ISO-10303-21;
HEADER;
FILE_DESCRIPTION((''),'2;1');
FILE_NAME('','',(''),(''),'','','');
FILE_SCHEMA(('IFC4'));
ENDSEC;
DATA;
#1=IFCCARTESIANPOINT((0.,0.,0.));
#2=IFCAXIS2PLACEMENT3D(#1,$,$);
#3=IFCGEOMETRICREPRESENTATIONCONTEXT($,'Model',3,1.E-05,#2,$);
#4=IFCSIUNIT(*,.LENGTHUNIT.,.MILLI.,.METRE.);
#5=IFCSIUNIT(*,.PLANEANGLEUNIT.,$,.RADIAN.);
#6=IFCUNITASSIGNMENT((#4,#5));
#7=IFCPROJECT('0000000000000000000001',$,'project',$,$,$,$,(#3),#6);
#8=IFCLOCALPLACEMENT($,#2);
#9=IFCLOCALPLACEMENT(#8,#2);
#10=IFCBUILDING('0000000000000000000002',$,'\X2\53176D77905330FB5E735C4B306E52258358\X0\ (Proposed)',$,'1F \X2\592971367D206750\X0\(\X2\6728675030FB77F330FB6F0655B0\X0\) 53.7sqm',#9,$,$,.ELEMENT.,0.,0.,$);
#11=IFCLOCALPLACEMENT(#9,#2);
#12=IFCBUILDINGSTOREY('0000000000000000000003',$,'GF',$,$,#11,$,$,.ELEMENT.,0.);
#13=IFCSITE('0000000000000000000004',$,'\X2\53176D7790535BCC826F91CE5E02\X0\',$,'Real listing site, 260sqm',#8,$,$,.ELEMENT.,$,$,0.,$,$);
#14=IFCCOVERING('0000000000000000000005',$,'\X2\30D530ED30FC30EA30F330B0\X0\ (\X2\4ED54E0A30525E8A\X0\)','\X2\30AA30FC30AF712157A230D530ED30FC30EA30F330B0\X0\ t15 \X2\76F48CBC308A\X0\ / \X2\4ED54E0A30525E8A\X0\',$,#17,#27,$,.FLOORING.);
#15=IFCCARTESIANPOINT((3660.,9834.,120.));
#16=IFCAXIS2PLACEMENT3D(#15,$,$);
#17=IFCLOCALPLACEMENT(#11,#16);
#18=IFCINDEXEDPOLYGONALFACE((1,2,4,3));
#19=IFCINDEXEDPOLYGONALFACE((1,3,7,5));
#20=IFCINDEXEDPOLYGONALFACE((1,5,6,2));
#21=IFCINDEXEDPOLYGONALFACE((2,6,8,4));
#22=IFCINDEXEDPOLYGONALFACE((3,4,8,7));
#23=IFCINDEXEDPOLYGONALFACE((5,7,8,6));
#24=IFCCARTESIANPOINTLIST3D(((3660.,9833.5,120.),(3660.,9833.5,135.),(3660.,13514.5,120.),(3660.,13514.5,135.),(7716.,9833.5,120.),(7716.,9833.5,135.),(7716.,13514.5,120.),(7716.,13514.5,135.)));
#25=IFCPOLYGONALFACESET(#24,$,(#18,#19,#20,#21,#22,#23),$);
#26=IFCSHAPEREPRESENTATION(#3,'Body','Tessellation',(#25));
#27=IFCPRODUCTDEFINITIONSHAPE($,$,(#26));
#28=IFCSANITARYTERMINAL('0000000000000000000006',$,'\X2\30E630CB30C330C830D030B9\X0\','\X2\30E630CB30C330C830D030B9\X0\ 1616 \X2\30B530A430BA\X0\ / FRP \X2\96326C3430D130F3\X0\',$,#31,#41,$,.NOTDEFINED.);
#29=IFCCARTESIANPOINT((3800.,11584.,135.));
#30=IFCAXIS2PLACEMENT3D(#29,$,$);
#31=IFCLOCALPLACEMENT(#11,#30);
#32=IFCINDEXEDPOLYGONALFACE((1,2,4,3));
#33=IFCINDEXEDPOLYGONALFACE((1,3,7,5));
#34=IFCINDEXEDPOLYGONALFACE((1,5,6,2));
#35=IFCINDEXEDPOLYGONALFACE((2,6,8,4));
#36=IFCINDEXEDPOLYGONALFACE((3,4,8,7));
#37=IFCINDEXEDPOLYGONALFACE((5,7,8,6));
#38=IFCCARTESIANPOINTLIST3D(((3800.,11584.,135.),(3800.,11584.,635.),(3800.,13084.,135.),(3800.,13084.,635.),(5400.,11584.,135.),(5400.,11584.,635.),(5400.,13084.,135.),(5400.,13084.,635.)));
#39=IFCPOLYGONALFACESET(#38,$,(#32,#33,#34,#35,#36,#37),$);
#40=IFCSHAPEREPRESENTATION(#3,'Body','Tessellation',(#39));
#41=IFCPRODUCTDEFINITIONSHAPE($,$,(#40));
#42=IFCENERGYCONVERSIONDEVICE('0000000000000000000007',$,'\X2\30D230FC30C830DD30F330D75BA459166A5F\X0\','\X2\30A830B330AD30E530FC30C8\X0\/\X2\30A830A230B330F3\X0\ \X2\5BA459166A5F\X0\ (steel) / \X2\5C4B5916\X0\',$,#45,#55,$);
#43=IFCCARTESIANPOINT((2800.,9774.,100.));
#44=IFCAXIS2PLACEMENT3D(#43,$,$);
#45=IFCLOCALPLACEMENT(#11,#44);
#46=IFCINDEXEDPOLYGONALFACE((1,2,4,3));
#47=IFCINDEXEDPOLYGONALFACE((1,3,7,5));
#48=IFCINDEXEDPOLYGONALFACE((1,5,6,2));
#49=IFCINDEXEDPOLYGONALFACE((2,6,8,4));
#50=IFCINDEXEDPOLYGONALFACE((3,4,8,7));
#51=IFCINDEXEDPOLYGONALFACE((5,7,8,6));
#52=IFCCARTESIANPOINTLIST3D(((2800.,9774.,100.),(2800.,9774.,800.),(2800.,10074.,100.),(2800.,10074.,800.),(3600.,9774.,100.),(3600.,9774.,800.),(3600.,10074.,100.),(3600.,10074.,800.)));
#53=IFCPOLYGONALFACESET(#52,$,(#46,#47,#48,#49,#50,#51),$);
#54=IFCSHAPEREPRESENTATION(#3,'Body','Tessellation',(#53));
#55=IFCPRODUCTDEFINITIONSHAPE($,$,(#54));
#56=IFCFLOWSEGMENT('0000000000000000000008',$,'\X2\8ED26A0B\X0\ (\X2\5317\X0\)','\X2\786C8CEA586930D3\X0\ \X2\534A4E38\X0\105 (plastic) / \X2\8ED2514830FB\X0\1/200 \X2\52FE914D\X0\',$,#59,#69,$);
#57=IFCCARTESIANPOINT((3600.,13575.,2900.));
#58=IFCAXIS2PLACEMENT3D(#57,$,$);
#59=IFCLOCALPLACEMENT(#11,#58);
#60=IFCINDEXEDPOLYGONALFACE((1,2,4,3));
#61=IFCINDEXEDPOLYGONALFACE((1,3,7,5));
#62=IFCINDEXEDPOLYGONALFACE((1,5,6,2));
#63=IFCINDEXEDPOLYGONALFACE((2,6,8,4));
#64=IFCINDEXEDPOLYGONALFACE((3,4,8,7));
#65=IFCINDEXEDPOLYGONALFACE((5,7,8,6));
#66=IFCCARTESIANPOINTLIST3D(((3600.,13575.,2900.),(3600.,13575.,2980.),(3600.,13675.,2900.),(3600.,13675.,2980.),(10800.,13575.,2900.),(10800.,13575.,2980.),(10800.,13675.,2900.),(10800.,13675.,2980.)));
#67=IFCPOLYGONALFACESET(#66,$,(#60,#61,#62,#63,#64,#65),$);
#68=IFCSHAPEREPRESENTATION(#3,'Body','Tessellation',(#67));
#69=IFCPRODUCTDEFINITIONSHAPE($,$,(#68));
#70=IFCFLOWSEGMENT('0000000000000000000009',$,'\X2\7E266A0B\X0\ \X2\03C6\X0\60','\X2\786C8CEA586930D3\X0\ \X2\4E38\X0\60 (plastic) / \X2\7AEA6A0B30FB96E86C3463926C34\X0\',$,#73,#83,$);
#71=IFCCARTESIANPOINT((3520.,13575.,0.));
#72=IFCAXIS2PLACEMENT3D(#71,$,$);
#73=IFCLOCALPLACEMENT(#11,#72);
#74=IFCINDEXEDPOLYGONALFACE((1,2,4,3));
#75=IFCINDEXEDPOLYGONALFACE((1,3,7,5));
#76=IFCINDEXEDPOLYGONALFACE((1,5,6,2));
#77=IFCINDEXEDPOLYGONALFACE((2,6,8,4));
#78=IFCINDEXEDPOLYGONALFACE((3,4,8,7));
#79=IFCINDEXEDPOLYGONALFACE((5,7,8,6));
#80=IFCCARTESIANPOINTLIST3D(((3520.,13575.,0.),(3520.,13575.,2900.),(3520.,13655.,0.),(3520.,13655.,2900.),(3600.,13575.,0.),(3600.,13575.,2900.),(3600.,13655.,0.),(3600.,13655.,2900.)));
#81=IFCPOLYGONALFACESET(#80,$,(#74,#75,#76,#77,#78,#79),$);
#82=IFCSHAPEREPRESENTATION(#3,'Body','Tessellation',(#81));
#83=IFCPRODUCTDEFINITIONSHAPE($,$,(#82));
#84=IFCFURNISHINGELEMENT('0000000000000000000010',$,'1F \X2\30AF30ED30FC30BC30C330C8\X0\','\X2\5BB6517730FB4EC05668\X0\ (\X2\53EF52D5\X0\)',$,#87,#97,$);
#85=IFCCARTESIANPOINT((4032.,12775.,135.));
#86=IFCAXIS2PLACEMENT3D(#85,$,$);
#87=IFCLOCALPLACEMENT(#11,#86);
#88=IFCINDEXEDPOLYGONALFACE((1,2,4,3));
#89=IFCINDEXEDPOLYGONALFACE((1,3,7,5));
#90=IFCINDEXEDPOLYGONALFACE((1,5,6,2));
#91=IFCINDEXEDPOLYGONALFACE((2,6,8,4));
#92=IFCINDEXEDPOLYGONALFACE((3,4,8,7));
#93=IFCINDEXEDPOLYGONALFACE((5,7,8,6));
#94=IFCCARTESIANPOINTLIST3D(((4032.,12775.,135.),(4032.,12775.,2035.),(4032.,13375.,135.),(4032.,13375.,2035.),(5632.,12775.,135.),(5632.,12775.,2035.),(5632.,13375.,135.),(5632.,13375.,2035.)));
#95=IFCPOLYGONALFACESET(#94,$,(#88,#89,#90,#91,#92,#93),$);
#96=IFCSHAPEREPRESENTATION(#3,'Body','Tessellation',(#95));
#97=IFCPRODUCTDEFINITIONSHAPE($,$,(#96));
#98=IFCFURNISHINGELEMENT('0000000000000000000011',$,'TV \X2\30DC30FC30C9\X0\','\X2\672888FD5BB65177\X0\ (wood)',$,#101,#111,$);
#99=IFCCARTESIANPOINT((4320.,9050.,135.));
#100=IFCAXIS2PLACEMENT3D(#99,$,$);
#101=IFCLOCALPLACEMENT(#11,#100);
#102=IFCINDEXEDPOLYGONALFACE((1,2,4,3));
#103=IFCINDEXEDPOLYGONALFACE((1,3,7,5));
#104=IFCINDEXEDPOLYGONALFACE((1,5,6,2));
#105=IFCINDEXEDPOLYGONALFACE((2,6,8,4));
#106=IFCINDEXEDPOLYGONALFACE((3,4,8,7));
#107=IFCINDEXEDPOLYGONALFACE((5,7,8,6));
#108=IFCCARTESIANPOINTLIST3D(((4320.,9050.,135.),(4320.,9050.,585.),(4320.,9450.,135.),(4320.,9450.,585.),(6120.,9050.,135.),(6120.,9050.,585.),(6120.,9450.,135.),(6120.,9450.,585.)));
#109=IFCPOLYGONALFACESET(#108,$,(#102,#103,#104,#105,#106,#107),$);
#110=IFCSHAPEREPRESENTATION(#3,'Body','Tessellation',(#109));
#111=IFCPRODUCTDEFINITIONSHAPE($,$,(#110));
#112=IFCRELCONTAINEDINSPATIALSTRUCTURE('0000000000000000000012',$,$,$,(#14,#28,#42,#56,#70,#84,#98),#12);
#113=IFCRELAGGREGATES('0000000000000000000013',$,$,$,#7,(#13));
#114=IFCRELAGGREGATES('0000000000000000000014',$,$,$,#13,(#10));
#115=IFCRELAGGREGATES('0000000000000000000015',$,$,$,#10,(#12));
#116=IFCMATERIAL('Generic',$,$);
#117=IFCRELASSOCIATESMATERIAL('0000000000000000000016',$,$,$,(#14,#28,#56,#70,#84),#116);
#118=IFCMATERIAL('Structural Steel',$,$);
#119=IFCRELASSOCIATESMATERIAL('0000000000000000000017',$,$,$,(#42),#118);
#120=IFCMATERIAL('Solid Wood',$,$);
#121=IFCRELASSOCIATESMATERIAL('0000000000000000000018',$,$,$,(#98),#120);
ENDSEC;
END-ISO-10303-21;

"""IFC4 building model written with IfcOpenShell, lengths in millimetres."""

from ifc_helpers import new_model, si_unit, frame, frame_2d, origin, place, context, project, spatial, rectangle, extrude, material, element, save


model = new_model("IFC4")

# Units and contexts
model_context = context("Model", 3, precision=1e-05, world=origin())
ifc_project = project(units=[si_unit("LENGTHUNIT", "METRE", prefix="MILLI"), si_unit("PLANEANGLEUNIT", "RADIAN")], contexts=[model_context])

# Site, building, storey
site_placement = place(None, origin())
site = spatial("IfcSite", under=ifc_project, at=site_placement, Name="北海道富良野市", ObjectType="Real listing site, 260sqm", CompositionType="ELEMENT", RefElevation=0.0)
building_placement = place(site_placement, origin())
building = spatial("IfcBuilding", under=site, at=building_placement, Name="北海道・平屋の別荘 (Proposed)", ObjectType="1F 天然素材(木材・石・漆喰) 53.7sqm", CompositionType="ELEMENT", ElevationOfRefHeight=0.0, ElevationOfTerrain=0.0)
storey_placement = place(building_placement, origin())
storey = spatial("IfcBuildingStorey", under=building, at=storey_placement, Name="GF", CompositionType="ELEMENT", Elevation=0.0)

# Shared definitions
ifc_material_1 = material(Name="Solid Wood")

# Shared definitions
ifc_material_2 = material(Name="Structural Steel")

# Covering
ifc_material_3 = material(Name="Generic")
covering_placement = place(storey_placement, frame((3660.0, 9834.0, 120.0)))
element("IfcCovering", 1, at=covering_placement, inside=storey, material=ifc_material_3, Name="フローリング (仕上げ床)", Description="オーク無垢フローリング t15 直貼り / 仕上げ床", PredefinedType="FLOORING", context=model_context, shape_type="SweptSolid", body=[
    extrude(rectangle(XDim=4056.0, YDim=3681.0, at=frame_2d((2028.0, 1840.0))), frame((3660.0, 9834.0, 120.0)), (0.0, 0.0, 1.0), 15.0),
])

# Sanitary terminal
sanitary_terminal_placement = place(storey_placement, frame((3800.0, 11584.0, 135.0)))
element("IfcSanitaryTerminal", 2, at=sanitary_terminal_placement, inside=storey, material=ifc_material_3, Name="ユニットバス", Description="ユニットバス 1616 サイズ / FRP 防水パン", PredefinedType="NOTDEFINED", context=model_context, shape_type="SweptSolid", body=[
    extrude(rectangle(XDim=1600.0, YDim=1500.0, at=frame_2d((800.0, 750.0))), frame((3800.0, 11584.0, 135.0)), (0.0, 0.0, 1.0), 500.0),
])

# Energy conversion device
energy_conversion_device_placement = place(storey_placement, frame((2800.0, 9774.0, 100.0)))
element("IfcEnergyConversionDevice", 3, at=energy_conversion_device_placement, inside=storey, material=ifc_material_2, Name="ヒートポンプ室外機", Description="エコキュート/エアコン 室外機 (steel) / 屋外", context=model_context, shape_type="SweptSolid", body=[
    extrude(rectangle(XDim=800.0, YDim=300.0, at=frame_2d((400.0, 150.0))), frame((2800.0, 9774.0, 100.0)), (0.0, 0.0, 1.0), 700.0),
])

# Flow segments
flow_segment_1_placement = place(storey_placement, frame((3600.0, 13575.0, 2900.0)))
element("IfcFlowSegment", 4, at=flow_segment_1_placement, inside=storey, material=ifc_material_3, Name="軒樋 (北)", Description="硬質塩ビ 半丸105 (plastic) / 軒先・1/200 勾配", context=model_context, shape_type="SweptSolid", body=[
    extrude(rectangle(XDim=7200.0, YDim=100.0, at=frame_2d((3600.0, 50.0))), frame((3600.0, 13575.0, 2900.0)), (0.0, 0.0, 1.0), 80.0),
])
flow_segment_2_placement = place(storey_placement, frame((3520.0, 13575.0, 0.0)))
element("IfcFlowSegment", 5, at=flow_segment_2_placement, inside=storey, material=ifc_material_3, Name="縦樋 φ60", Description="硬質塩ビ 丸60 (plastic) / 竪樋・雨水排水", context=model_context, shape_type="SweptSolid", body=[
    extrude(rectangle(XDim=80.0, YDim=80.0, at=frame_2d((40.0, 40.0))), frame((3520.0, 13575.0, 0.0)), (0.0, 0.0, 1.0), 2900.0),
])

# Furnishing elements
furnishing_1_placement = place(storey_placement, frame((4032.0, 12775.0, 135.0)))
element("IfcFurnishingElement", 6, at=furnishing_1_placement, inside=storey, material=ifc_material_3, Name="1F クローゼット", Description="家具・什器 (可動)", context=model_context, shape_type="SweptSolid", body=[
    extrude(rectangle(XDim=1600.0, YDim=600.0, at=frame_2d((800.0, 300.0))), frame((4032.0, 12775.0, 135.0)), (0.0, 0.0, 1.0), 1900.0),
])
furnishing_2_placement = place(storey_placement, frame((4320.0, 9050.0, 135.0)))
element("IfcFurnishingElement", 7, at=furnishing_2_placement, inside=storey, material=ifc_material_1, Name="TV ボード", Description="木製家具 (wood)", context=model_context, shape_type="SweptSolid", body=[
    extrude(rectangle(XDim=1800.0, YDim=400.0, at=frame_2d((900.0, 200.0))), frame((4320.0, 9050.0, 135.0)), (0.0, 0.0, 1.0), 450.0),
])

save(model, "model.ifc")
